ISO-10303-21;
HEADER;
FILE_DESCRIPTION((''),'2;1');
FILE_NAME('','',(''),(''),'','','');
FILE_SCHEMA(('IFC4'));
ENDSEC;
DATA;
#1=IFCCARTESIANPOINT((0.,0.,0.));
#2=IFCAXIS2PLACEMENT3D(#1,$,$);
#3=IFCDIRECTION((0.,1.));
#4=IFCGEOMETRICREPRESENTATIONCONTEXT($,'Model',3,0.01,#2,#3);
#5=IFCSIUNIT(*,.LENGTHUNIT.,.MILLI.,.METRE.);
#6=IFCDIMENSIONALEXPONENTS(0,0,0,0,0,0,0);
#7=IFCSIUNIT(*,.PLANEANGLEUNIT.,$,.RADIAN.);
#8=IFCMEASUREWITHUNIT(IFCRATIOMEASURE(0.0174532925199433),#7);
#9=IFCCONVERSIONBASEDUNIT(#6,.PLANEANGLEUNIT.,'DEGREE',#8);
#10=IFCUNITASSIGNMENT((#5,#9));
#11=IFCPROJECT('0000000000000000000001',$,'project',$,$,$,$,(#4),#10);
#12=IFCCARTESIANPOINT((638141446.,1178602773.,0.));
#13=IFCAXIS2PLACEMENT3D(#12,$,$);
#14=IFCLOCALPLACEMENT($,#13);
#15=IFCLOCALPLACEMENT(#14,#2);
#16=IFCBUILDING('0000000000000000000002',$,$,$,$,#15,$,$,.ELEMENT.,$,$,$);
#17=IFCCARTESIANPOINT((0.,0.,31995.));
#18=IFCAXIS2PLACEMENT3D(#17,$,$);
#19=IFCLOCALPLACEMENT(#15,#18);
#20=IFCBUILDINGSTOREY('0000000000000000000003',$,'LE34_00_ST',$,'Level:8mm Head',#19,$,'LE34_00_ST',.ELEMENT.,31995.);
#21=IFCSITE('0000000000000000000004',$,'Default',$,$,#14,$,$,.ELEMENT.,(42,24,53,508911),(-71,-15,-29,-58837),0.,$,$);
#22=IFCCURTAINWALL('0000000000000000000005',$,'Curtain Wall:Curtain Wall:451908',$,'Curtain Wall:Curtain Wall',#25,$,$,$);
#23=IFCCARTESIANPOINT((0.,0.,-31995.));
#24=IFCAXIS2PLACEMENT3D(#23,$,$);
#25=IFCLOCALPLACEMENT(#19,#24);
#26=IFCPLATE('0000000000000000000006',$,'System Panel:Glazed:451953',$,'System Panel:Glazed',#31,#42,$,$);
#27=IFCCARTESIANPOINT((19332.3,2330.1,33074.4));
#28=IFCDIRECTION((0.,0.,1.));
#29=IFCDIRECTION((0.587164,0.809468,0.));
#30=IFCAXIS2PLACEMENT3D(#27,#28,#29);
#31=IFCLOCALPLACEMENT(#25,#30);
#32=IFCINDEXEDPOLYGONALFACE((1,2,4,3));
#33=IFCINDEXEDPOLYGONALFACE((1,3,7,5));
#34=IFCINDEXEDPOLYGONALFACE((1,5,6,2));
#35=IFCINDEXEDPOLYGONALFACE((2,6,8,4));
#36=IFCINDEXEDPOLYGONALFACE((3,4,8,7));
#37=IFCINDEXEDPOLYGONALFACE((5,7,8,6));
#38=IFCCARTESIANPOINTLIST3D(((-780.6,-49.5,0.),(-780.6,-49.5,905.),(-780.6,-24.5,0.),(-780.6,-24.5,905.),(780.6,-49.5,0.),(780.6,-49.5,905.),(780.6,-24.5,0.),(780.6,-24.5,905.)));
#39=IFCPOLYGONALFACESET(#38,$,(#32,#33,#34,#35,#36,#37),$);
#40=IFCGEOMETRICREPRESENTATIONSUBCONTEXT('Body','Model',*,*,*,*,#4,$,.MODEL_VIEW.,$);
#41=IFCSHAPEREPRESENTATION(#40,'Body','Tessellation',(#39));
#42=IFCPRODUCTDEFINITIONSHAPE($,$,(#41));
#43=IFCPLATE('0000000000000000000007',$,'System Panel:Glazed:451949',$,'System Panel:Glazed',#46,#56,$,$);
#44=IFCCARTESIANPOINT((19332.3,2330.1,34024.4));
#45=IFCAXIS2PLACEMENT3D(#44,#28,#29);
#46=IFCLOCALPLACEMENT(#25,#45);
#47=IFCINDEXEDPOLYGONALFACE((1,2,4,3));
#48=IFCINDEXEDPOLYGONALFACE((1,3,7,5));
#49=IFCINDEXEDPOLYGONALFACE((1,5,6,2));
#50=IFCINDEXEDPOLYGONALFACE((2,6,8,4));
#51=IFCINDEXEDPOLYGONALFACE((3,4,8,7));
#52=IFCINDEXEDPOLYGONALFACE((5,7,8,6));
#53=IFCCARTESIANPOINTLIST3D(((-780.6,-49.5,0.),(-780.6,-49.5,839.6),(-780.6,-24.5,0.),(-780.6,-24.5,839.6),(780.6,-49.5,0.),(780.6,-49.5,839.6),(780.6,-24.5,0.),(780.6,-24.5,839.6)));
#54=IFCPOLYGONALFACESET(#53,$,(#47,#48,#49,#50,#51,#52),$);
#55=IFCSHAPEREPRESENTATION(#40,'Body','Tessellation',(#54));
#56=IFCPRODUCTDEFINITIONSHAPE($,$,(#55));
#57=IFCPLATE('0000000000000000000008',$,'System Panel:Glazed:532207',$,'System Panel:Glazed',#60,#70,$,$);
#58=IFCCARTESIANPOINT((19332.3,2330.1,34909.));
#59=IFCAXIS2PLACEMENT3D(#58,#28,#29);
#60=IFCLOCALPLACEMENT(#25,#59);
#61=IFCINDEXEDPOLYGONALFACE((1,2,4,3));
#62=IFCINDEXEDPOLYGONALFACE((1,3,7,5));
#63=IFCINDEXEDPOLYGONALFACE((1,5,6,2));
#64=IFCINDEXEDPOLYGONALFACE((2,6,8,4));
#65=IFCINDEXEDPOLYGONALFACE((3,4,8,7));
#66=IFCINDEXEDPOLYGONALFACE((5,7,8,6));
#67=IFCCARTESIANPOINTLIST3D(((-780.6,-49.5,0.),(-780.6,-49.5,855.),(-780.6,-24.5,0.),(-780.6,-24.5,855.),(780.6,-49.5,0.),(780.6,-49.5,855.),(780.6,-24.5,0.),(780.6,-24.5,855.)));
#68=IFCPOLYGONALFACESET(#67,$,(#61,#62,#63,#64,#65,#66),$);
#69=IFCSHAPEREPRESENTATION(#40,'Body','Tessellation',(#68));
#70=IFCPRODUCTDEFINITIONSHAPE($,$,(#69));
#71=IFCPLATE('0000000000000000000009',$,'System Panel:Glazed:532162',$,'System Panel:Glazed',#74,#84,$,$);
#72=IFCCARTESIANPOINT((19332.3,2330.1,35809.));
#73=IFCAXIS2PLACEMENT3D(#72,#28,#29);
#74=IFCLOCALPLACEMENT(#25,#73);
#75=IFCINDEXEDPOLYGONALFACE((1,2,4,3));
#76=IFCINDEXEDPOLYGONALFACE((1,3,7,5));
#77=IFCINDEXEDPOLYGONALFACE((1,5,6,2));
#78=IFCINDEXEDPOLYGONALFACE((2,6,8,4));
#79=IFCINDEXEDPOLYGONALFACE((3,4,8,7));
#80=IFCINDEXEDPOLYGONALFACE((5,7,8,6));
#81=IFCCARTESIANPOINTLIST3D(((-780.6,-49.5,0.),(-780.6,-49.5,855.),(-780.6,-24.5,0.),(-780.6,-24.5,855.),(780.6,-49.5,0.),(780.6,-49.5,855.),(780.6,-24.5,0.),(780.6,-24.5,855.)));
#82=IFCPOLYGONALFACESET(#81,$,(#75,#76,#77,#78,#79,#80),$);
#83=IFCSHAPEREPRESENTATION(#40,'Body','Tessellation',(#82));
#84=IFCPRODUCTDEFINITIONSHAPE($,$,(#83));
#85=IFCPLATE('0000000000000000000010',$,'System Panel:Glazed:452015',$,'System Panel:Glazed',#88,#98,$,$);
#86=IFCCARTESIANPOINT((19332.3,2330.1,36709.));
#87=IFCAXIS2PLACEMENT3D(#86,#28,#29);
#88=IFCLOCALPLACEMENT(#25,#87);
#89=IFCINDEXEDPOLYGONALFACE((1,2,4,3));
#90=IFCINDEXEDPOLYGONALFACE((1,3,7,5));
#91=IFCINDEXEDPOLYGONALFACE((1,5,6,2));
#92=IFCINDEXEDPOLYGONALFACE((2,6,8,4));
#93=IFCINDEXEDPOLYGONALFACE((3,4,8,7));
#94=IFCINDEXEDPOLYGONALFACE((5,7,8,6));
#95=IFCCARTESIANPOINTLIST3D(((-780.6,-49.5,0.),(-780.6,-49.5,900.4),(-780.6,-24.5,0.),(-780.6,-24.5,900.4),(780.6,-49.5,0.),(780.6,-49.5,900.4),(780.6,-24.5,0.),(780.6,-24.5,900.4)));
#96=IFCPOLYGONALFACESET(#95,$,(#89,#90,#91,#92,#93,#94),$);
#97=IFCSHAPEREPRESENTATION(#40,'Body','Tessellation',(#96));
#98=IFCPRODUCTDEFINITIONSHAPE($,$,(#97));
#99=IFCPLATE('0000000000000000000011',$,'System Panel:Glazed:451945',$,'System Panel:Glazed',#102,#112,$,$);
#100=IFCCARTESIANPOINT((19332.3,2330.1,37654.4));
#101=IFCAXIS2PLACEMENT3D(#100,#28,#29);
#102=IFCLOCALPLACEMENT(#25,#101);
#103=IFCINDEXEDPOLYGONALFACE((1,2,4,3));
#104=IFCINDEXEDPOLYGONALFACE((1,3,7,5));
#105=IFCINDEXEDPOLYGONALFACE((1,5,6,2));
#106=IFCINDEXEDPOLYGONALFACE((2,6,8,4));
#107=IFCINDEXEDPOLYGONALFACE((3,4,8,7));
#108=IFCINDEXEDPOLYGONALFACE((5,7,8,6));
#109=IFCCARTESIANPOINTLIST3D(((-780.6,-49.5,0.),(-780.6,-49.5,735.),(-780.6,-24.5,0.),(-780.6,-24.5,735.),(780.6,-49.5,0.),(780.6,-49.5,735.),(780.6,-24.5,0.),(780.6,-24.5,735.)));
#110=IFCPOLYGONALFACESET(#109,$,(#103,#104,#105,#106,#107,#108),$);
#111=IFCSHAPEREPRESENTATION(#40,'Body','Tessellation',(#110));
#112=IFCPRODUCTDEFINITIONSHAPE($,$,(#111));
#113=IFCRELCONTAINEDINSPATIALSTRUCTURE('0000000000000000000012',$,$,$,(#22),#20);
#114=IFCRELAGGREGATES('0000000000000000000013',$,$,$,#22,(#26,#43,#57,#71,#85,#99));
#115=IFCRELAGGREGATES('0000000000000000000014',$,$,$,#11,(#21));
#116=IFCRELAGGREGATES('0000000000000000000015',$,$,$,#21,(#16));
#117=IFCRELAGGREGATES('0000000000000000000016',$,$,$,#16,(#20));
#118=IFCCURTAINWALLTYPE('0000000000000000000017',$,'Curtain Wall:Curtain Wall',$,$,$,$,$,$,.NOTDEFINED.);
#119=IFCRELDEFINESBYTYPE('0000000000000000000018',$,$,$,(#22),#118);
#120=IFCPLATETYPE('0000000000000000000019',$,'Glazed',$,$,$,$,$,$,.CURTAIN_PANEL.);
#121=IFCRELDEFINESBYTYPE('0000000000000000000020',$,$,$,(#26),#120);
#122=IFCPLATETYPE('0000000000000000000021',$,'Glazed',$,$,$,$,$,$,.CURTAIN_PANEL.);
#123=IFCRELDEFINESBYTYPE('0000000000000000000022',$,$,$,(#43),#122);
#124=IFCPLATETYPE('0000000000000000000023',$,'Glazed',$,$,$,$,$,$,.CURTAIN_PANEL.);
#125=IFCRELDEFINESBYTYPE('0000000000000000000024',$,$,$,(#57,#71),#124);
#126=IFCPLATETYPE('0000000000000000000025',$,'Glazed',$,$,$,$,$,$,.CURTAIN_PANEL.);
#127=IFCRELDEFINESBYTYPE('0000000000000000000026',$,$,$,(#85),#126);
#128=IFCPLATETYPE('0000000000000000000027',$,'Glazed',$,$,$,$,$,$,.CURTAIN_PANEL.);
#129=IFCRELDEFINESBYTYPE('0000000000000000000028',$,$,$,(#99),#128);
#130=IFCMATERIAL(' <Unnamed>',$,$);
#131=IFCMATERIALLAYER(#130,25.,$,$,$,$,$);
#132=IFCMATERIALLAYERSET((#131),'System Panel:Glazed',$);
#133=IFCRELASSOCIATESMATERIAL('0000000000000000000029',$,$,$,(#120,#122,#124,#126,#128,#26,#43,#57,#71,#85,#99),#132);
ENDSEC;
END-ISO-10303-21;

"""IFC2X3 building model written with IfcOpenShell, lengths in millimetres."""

from ifc_helpers import new_model, entity, si_unit, converted_unit, direction, frame, frame_2d, origin, place, context, subcontext, project, spatial, rectangle, extrude, source, transform, mapped, material, layer, layer_set, layer_usage, type_object, type_shapes, element, aggregate, save


model = new_model("IFC2X3")

# Units and contexts
model_context = context("Model", 3, precision=0.01, world=origin(), true_north=direction((0.0, 1.0)))
body_context = subcontext(model_context, "Body", "Model", "MODEL_VIEW")
ifc_project = project(units=[si_unit("LENGTHUNIT", "METRE", prefix="MILLI"), converted_unit("PLANEANGLEUNIT", "DEGREE", entity("IfcRatioMeasure", 0.0174532925199433), si_unit("PLANEANGLEUNIT", "RADIAN"), dimensions=[0, 0, 0, 0, 0, 0, 0])], contexts=[model_context])

# Site, building, storey
site_placement = place(None, frame((638141446.0, 1178602773.0, 0.0)))
site = spatial("IfcSite", under=ifc_project, at=site_placement, Name="Default", CompositionType="ELEMENT", RefLatitude=(42, 24, 53, 508911), RefLongitude=(-71, -15, -29, -58837), RefElevation=0.0)
building_placement = place(site_placement, origin())
building = spatial("IfcBuilding", under=site, at=building_placement, CompositionType="ELEMENT")
storey_placement = place(building_placement, frame((0.0, 0.0, 31995.0)))
storey = spatial("IfcBuildingStorey", under=building, at=storey_placement, Name="LE34_00_ST", ObjectType="Level:8mm Head", LongName="LE34_00_ST", CompositionType="ELEMENT", Elevation=31995.0)

# Curtain wall
curtain_wall_type = type_object("IfcCurtainWallType", Name="Curtain Wall:Curtain Wall", PredefinedType="NOTDEFINED")
curtain_wall_1_placement = place(storey_placement, frame((0.0, 0.0, -31995.0)))
curtain_wall_1 = element("IfcCurtainWall", 1, at=curtain_wall_1_placement, inside=storey, type_object=curtain_wall_type, Name="Curtain Wall:Curtain Wall:451908", ObjectType="Curtain Wall:Curtain Wall")

# Plates
ifc_material_1 = material(Name=" <Unnamed>")
ifc_layer_1 = layer(ifc_material_1, 25.0)
ifc_layer_set_1 = layer_set([ifc_layer_1], Name="System Panel:Glazed")
ifc_layer_usage_1 = layer_usage(ifc_layer_set_1, "AXIS3", "POSITIVE", 0.1)
plate_type_1 = type_object("IfcPlateType", Name="Glazed", PredefinedType="CURTAIN_PANEL", material=ifc_layer_set_1)
shared_shape_1 = source(origin(), body_context, "Body", "SweptSolid", [
    extrude(rectangle(XDim=25.0, YDim=1561.3, at=frame_2d((0.0, 0.0), x_axis=(1.0, 0.0))), frame((0.0, -37.0, 0.0), z_axis=(0.0, 0.0, 1.0), x_axis=(0.0, 1.0, 0.0)), (0.0, 0.0, 1.0), 905.0),
])
type_shapes(plate_type_1, [shared_shape_1])
plate_1_placement = place(curtain_wall_1_placement, frame((19332.3, 2330.1, 33074.4), z_axis=(0.0, 0.0, 1.0), x_axis=(0.587164, 0.809468, 0.0)))
plate_1 = element("IfcPlate", 2, at=plate_1_placement, type_object=plate_type_1, material=ifc_layer_usage_1, Name="System Panel:Glazed:451953", ObjectType="System Panel:Glazed", context=body_context, shape_type="MappedRepresentation", body=[
    mapped(shared_shape_1, transform((0.0, 0.0, 0.0), scale=1.0)),
])
ifc_layer_usage_2 = layer_usage(ifc_layer_set_1, "AXIS3", "POSITIVE", 0.1)
plate_type_2 = type_object("IfcPlateType", Name="Glazed", PredefinedType="CURTAIN_PANEL", material=ifc_layer_set_1)
shared_shape_2 = source(origin(), body_context, "Body", "SweptSolid", [
    extrude(rectangle(XDim=25.0, YDim=1561.3, at=frame_2d((0.0, 0.0), x_axis=(1.0, 0.0))), frame((0.0, -37.0, 0.0), z_axis=(0.0, 0.0, 1.0), x_axis=(0.0, 1.0, 0.0)), (0.0, 0.0, 1.0), 839.6),
])
type_shapes(plate_type_2, [shared_shape_2])
plate_2_placement = place(curtain_wall_1_placement, frame((19332.3, 2330.1, 34024.4), z_axis=(0.0, 0.0, 1.0), x_axis=(0.587164, 0.809468, 0.0)))
plate_2 = element("IfcPlate", 3, at=plate_2_placement, type_object=plate_type_2, material=ifc_layer_usage_2, Name="System Panel:Glazed:451949", ObjectType="System Panel:Glazed", context=body_context, shape_type="MappedRepresentation", body=[
    mapped(shared_shape_2, transform((0.0, 0.0, 0.0), scale=1.0)),
])
ifc_layer_usage_3 = layer_usage(ifc_layer_set_1, "AXIS3", "POSITIVE", 0.1)
plate_type_3 = type_object("IfcPlateType", Name="Glazed", PredefinedType="CURTAIN_PANEL", material=ifc_layer_set_1)
shared_shape_3 = source(origin(), body_context, "Body", "SweptSolid", [
    extrude(rectangle(XDim=25.0, YDim=1561.3, at=frame_2d((0.0, 0.0), x_axis=(1.0, 0.0))), frame((0.0, -37.0, 0.0), z_axis=(0.0, 0.0, 1.0), x_axis=(0.0, 1.0, 0.0)), (0.0, 0.0, 1.0), 855.0),
])
type_shapes(plate_type_3, [shared_shape_3])
plate_3_placement = place(curtain_wall_1_placement, frame((19332.3, 2330.1, 34909.0), z_axis=(0.0, 0.0, 1.0), x_axis=(0.587164, 0.809468, 0.0)))
plate_3 = element("IfcPlate", 4, at=plate_3_placement, type_object=plate_type_3, material=ifc_layer_usage_3, Name="System Panel:Glazed:532207", ObjectType="System Panel:Glazed", context=body_context, shape_type="MappedRepresentation", body=[
    mapped(shared_shape_3, transform((0.0, 0.0, 0.0), scale=1.0)),
])
ifc_layer_usage_4 = layer_usage(ifc_layer_set_1, "AXIS3", "POSITIVE", 0.1)
plate_4_placement = place(curtain_wall_1_placement, frame((19332.3, 2330.1, 35809.0), z_axis=(0.0, 0.0, 1.0), x_axis=(0.587164, 0.809468, 0.0)))
plate_4 = element("IfcPlate", 5, at=plate_4_placement, type_object=plate_type_3, material=ifc_layer_usage_4, Name="System Panel:Glazed:532162", ObjectType="System Panel:Glazed", context=body_context, shape_type="MappedRepresentation", body=[
    mapped(shared_shape_3, transform((0.0, 0.0, 0.0), scale=1.0)),
])
ifc_layer_usage_5 = layer_usage(ifc_layer_set_1, "AXIS3", "POSITIVE", 0.1)
plate_type_4 = type_object("IfcPlateType", Name="Glazed", PredefinedType="CURTAIN_PANEL", material=ifc_layer_set_1)
shared_shape_4 = source(origin(), body_context, "Body", "SweptSolid", [
    extrude(rectangle(XDim=25.0, YDim=1561.3, at=frame_2d((0.0, 0.0), x_axis=(1.0, 0.0))), frame((0.0, -37.0, 0.0), z_axis=(0.0, 0.0, 1.0), x_axis=(0.0, 1.0, 0.0)), (0.0, 0.0, 1.0), 900.4),
])
type_shapes(plate_type_4, [shared_shape_4])
plate_5_placement = place(curtain_wall_1_placement, frame((19332.3, 2330.1, 36709.0), z_axis=(0.0, 0.0, 1.0), x_axis=(0.587164, 0.809468, 0.0)))
plate_5 = element("IfcPlate", 6, at=plate_5_placement, type_object=plate_type_4, material=ifc_layer_usage_5, Name="System Panel:Glazed:452015", ObjectType="System Panel:Glazed", context=body_context, shape_type="MappedRepresentation", body=[
    mapped(shared_shape_4, transform((0.0, 0.0, 0.0), scale=1.0)),
])
ifc_layer_usage_6 = layer_usage(ifc_layer_set_1, "AXIS3", "POSITIVE", 0.1)
plate_type_5 = type_object("IfcPlateType", Name="Glazed", PredefinedType="CURTAIN_PANEL", material=ifc_layer_set_1)
shared_shape_5 = source(origin(), body_context, "Body", "SweptSolid", [
    extrude(rectangle(XDim=25.0, YDim=1561.3, at=frame_2d((0.0, 0.0), x_axis=(1.0, 0.0))), frame((0.0, -37.0, 0.0), z_axis=(0.0, 0.0, 1.0), x_axis=(0.0, 1.0, 0.0)), (0.0, 0.0, 1.0), 735.0),
])
type_shapes(plate_type_5, [shared_shape_5])
plate_6_placement = place(curtain_wall_1_placement, frame((19332.3, 2330.1, 37654.4), z_axis=(0.0, 0.0, 1.0), x_axis=(0.587164, 0.809468, 0.0)))
plate_6 = element("IfcPlate", 7, at=plate_6_placement, type_object=plate_type_5, material=ifc_layer_usage_6, Name="System Panel:Glazed:451945", ObjectType="System Panel:Glazed", context=body_context, shape_type="MappedRepresentation", body=[
    mapped(shared_shape_5, transform((0.0, 0.0, 0.0), scale=1.0)),
])
aggregate(curtain_wall_1, [plate_1, plate_2, plate_3, plate_4, plate_5, plate_6])

save(model, "model.ifc")
